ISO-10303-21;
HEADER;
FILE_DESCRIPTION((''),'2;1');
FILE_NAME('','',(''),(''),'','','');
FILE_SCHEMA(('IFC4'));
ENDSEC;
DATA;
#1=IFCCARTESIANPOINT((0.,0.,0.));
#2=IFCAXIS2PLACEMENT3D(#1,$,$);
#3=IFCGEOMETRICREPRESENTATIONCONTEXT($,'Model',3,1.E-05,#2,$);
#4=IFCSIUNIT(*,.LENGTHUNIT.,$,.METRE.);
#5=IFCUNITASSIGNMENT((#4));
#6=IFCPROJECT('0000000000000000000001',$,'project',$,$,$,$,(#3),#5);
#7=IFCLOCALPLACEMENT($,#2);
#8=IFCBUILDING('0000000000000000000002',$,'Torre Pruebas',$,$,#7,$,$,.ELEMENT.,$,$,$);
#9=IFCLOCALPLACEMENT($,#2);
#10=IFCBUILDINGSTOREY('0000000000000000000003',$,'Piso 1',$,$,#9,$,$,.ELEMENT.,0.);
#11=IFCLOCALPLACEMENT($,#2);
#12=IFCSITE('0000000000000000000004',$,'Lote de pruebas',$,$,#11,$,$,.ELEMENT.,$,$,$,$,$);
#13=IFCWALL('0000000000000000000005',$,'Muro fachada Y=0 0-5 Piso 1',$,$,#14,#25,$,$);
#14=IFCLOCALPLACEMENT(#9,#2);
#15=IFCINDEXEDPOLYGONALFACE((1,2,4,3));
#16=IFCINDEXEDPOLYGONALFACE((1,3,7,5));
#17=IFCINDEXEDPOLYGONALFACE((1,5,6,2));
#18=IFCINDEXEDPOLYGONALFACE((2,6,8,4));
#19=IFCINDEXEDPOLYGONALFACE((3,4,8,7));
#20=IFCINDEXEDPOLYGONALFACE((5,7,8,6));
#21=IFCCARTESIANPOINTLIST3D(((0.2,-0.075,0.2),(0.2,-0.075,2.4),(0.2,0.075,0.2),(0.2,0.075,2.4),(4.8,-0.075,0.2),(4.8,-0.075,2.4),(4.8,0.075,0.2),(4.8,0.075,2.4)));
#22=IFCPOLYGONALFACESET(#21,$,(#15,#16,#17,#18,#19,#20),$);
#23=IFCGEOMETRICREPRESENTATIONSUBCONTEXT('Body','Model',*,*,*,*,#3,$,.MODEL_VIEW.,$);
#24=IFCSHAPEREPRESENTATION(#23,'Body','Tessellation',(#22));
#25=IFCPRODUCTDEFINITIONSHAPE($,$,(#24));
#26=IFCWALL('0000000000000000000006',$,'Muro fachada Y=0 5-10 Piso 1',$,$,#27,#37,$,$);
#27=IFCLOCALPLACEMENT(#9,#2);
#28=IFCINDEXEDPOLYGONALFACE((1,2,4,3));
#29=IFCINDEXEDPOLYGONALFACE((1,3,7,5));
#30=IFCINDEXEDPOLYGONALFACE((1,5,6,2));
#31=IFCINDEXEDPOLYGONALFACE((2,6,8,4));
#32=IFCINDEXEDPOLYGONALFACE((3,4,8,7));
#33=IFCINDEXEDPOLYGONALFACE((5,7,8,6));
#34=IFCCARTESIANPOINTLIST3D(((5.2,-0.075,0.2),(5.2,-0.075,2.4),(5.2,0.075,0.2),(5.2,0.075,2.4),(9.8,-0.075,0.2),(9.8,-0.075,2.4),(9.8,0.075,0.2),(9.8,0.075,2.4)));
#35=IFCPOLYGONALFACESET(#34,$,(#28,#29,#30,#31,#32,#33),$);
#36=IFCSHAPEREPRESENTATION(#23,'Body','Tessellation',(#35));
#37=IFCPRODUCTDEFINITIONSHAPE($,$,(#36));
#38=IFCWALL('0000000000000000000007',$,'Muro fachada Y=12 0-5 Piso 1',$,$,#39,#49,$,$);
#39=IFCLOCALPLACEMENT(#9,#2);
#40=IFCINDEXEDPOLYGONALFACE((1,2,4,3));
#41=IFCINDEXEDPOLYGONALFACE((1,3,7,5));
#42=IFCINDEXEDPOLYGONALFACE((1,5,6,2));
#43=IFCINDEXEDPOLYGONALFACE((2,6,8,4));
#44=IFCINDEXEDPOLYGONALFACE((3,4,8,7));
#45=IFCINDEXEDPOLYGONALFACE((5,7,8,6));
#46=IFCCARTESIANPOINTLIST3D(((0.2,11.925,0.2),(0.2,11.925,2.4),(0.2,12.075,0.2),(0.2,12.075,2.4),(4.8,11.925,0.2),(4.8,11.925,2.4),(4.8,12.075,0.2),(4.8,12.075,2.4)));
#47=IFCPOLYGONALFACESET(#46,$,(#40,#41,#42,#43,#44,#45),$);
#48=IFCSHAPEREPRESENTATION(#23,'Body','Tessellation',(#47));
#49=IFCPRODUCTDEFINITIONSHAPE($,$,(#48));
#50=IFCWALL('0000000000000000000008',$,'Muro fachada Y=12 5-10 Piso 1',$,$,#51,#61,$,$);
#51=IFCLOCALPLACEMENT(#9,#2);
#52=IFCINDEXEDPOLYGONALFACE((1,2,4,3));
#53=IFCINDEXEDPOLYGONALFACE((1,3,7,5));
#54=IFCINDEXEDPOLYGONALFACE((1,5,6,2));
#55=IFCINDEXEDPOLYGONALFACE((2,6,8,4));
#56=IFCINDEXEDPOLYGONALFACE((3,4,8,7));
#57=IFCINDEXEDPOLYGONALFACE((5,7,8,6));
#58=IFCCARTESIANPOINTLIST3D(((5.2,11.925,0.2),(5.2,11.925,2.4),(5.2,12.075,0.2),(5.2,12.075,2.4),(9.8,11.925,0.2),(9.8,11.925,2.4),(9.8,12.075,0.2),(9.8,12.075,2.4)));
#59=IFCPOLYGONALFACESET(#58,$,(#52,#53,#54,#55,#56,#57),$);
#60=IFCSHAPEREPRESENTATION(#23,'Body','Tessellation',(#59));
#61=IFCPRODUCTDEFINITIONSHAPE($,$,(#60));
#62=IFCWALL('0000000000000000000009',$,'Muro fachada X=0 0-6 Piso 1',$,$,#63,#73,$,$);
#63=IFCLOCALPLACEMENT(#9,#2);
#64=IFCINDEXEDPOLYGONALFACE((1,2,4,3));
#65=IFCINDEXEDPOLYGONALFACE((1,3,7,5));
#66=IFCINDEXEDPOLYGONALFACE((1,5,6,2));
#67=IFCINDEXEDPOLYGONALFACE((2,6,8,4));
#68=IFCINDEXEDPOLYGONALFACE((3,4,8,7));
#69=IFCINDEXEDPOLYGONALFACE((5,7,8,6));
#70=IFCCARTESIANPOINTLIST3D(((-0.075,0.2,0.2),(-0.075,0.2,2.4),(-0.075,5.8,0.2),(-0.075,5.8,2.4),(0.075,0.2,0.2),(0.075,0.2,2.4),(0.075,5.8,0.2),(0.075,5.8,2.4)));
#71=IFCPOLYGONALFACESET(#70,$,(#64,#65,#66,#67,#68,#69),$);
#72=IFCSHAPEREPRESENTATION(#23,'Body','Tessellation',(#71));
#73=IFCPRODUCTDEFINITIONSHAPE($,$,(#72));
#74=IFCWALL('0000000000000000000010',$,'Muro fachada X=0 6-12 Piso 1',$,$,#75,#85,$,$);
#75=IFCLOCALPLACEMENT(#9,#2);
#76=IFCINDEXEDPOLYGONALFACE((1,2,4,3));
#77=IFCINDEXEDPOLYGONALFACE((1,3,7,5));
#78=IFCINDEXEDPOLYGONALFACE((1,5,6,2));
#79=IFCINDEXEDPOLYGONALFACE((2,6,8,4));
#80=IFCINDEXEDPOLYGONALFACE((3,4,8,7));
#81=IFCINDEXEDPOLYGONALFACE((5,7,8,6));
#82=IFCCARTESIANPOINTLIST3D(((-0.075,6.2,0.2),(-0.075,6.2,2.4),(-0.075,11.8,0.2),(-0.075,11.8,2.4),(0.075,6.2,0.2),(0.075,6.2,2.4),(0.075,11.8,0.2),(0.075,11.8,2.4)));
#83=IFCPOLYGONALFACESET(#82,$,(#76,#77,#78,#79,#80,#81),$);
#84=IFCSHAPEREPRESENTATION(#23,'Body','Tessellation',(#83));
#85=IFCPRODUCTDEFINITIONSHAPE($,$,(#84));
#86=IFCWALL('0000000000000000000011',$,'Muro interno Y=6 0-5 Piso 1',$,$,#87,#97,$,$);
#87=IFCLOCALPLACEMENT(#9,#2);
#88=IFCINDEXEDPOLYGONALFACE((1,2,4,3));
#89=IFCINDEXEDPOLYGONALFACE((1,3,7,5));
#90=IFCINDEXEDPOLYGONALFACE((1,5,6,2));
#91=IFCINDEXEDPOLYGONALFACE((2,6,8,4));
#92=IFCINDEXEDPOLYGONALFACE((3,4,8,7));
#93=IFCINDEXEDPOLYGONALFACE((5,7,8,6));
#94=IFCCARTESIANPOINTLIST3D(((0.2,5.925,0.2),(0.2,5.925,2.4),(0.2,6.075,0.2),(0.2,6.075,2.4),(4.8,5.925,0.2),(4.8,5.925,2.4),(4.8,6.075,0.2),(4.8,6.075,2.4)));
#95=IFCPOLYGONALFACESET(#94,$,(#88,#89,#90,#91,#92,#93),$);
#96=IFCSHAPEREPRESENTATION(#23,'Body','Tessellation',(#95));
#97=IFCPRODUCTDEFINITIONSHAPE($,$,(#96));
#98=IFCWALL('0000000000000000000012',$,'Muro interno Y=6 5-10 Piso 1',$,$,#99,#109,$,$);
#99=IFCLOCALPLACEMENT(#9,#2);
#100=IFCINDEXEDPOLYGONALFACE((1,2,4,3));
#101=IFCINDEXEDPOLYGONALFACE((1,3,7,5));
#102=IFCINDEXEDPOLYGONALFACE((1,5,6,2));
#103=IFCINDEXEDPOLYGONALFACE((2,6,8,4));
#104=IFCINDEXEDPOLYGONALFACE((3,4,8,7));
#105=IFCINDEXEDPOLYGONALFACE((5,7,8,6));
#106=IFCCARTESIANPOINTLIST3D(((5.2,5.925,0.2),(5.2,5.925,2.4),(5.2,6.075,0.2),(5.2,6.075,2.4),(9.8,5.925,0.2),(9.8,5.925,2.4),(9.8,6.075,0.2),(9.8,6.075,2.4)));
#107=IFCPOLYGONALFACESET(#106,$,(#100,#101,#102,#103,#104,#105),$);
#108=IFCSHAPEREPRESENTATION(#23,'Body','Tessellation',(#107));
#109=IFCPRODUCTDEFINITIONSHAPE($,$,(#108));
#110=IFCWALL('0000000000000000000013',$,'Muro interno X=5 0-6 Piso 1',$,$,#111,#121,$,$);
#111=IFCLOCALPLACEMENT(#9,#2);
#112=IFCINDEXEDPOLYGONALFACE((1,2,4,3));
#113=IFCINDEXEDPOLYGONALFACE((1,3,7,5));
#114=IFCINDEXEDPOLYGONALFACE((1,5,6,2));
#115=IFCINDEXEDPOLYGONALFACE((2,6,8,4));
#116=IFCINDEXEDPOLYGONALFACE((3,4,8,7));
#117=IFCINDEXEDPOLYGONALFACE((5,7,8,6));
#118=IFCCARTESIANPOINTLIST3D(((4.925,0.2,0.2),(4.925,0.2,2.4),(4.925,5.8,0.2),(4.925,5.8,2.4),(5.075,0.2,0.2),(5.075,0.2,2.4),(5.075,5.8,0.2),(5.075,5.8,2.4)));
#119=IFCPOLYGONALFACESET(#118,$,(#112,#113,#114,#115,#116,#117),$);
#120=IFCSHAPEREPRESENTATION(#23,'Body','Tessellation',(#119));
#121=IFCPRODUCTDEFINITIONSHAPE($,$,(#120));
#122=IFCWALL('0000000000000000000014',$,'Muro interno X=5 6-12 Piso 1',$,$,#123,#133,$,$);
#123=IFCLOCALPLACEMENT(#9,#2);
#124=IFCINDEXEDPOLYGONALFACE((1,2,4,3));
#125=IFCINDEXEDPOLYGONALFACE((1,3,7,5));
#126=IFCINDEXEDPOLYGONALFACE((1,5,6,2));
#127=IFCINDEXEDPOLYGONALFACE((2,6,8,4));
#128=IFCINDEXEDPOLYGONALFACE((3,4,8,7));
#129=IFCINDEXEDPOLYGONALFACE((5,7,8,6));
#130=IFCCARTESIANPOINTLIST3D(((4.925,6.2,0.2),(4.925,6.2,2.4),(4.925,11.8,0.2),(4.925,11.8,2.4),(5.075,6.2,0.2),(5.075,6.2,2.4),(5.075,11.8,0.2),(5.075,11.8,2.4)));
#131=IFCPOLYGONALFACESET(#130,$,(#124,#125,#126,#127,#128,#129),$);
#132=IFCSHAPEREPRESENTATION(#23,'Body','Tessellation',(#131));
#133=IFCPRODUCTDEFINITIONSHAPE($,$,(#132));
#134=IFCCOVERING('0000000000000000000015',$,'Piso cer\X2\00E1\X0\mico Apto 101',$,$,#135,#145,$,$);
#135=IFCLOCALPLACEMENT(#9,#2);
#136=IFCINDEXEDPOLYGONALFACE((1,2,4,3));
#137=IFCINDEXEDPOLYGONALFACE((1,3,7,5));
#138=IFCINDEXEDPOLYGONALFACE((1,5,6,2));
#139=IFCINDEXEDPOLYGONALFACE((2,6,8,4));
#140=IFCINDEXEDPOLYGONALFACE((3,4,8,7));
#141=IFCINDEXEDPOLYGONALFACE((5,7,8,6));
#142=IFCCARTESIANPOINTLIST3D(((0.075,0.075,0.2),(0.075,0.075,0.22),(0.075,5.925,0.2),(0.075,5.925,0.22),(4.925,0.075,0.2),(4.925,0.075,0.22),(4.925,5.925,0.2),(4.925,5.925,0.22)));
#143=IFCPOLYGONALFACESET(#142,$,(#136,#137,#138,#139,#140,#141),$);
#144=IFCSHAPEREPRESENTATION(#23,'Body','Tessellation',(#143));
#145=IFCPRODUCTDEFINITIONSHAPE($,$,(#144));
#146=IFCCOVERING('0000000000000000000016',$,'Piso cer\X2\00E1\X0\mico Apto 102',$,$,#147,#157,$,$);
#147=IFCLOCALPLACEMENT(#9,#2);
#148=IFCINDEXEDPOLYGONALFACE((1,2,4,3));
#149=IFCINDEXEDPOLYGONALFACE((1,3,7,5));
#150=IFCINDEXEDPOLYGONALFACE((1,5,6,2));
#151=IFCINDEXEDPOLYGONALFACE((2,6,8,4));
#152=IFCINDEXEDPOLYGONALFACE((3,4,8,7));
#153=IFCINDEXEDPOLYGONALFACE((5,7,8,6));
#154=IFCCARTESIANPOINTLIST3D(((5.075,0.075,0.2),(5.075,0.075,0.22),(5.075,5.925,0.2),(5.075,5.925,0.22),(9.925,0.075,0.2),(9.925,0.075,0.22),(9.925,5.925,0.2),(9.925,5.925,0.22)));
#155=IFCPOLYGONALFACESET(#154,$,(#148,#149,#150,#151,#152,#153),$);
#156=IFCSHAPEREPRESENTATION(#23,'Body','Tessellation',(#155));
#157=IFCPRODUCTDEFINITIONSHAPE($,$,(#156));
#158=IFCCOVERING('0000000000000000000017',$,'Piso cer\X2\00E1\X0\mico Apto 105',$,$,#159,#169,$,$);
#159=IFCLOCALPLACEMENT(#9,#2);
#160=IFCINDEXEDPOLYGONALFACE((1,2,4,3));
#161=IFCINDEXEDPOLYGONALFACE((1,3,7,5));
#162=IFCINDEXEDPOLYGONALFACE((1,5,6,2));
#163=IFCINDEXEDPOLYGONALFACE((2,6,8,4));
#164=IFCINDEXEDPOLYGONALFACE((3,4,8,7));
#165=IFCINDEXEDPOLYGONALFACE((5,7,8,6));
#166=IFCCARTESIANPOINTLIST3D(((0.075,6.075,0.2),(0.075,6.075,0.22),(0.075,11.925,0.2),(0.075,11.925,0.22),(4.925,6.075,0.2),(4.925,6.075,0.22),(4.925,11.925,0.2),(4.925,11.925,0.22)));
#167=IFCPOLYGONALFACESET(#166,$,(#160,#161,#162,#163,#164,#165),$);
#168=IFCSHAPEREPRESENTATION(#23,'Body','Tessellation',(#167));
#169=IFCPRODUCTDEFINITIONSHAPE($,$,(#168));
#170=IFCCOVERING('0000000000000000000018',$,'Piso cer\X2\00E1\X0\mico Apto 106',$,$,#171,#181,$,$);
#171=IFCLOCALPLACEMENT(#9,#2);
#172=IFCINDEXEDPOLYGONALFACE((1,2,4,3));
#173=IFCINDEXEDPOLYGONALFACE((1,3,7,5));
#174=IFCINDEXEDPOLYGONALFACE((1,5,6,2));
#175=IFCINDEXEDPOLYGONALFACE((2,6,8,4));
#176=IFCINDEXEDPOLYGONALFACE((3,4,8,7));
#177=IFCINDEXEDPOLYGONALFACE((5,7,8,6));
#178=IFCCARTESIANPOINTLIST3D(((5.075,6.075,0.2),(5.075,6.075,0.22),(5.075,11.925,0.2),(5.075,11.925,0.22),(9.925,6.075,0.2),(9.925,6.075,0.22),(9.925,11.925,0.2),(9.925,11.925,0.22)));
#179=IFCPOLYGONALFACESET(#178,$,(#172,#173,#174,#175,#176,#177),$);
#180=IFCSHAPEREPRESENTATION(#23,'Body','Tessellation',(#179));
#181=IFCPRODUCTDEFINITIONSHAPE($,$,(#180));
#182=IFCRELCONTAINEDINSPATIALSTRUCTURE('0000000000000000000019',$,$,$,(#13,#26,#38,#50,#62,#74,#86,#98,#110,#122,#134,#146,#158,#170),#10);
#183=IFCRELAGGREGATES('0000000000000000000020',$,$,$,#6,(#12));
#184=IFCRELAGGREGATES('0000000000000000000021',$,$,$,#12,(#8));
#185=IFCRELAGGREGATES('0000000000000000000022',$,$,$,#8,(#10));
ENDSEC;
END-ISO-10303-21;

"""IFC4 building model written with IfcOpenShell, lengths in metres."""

from ifc_helpers import new_model, si_unit, frame, origin, origin_2d, place, context, subcontext, project, spatial, rectangle, extrude, element, save


model = new_model("IFC4")

# Units and contexts
model_context = context("Model", 3, precision=1e-05, world=origin())
body_context = subcontext(model_context, "Body", "Model", "MODEL_VIEW")
ifc_project = project(units=[si_unit("LENGTHUNIT", "METRE")], contexts=[model_context])

# Site, building, storey
site_placement = place(None, origin())
site = spatial("IfcSite", under=ifc_project, at=site_placement, Name="Lote de pruebas", CompositionType="ELEMENT")
building_placement = place(None, origin())
building = spatial("IfcBuilding", under=site, at=building_placement, Name="Torre Pruebas", CompositionType="ELEMENT")
storey_placement = place(None, origin())
storey = spatial("IfcBuildingStorey", under=building, at=storey_placement, Name="Piso 1", CompositionType="ELEMENT", Elevation=0.0)

# Walls
for number, where, name in (
    (1, (2.5, 0.0, 0.2), "Muro fachada Y=0 0-5 Piso 1"),
    (2, (7.5, 0.0, 0.2), "Muro fachada Y=0 5-10 Piso 1"),
    (3, (2.5, 12.0, 0.2), "Muro fachada Y=12 0-5 Piso 1"),
    (4, (7.5, 12.0, 0.2), "Muro fachada Y=12 5-10 Piso 1"),
):
    element("IfcWall", number, at=place(None, frame(where)), inside=storey, Name=name, context=body_context, shape_type="SweptSolid", body=[
        extrude(rectangle(XDim=4.6, YDim=0.15, at=origin_2d()), origin(), (0.0, 0.0, 1.0), 2.2),
    ])
for number, where, name in (
    (5, (0.0, 3.0, 0.2), "Muro fachada X=0 0-6 Piso 1"),
    (6, (0.0, 9.0, 0.2), "Muro fachada X=0 6-12 Piso 1"),
):
    element("IfcWall", number, at=place(None, frame(where)), inside=storey, Name=name, context=body_context, shape_type="SweptSolid", body=[
        extrude(rectangle(XDim=0.15, YDim=5.6, at=origin_2d()), origin(), (0.0, 0.0, 1.0), 2.2),
    ])
for number, where, name in (
    (7, (2.5, 6.0, 0.2), "Muro interno Y=6 0-5 Piso 1"),
    (8, (7.5, 6.0, 0.2), "Muro interno Y=6 5-10 Piso 1"),
):
    element("IfcWall", number, at=place(None, frame(where)), inside=storey, Name=name, context=body_context, shape_type="SweptSolid", body=[
        extrude(rectangle(XDim=4.6, YDim=0.15, at=origin_2d()), origin(), (0.0, 0.0, 1.0), 2.2),
    ])
for number, where, name in (
    (9, (5.0, 3.0, 0.2), "Muro interno X=5 0-6 Piso 1"),
    (10, (5.0, 9.0, 0.2), "Muro interno X=5 6-12 Piso 1"),
):
    element("IfcWall", number, at=place(None, frame(where)), inside=storey, Name=name, context=body_context, shape_type="SweptSolid", body=[
        extrude(rectangle(XDim=0.15, YDim=5.6, at=origin_2d()), origin(), (0.0, 0.0, 1.0), 2.2),
    ])

# Coverings
for number, where, name in (
    (11, (2.5, 3.0, 0.2), "Piso cerámico Apto 101"),
    (12, (7.5, 3.0, 0.2), "Piso cerámico Apto 102"),
    (13, (2.5, 9.0, 0.2), "Piso cerámico Apto 105"),
    (14, (7.5, 9.0, 0.2), "Piso cerámico Apto 106"),
):
    element("IfcCovering", number, at=place(None, frame(where)), inside=storey, Name=name, context=body_context, shape_type="SweptSolid", body=[
        extrude(rectangle(XDim=4.85, YDim=5.85, at=origin_2d()), origin(), (0.0, 0.0, 1.0), 0.02),
    ])

save(model, "model.ifc")
